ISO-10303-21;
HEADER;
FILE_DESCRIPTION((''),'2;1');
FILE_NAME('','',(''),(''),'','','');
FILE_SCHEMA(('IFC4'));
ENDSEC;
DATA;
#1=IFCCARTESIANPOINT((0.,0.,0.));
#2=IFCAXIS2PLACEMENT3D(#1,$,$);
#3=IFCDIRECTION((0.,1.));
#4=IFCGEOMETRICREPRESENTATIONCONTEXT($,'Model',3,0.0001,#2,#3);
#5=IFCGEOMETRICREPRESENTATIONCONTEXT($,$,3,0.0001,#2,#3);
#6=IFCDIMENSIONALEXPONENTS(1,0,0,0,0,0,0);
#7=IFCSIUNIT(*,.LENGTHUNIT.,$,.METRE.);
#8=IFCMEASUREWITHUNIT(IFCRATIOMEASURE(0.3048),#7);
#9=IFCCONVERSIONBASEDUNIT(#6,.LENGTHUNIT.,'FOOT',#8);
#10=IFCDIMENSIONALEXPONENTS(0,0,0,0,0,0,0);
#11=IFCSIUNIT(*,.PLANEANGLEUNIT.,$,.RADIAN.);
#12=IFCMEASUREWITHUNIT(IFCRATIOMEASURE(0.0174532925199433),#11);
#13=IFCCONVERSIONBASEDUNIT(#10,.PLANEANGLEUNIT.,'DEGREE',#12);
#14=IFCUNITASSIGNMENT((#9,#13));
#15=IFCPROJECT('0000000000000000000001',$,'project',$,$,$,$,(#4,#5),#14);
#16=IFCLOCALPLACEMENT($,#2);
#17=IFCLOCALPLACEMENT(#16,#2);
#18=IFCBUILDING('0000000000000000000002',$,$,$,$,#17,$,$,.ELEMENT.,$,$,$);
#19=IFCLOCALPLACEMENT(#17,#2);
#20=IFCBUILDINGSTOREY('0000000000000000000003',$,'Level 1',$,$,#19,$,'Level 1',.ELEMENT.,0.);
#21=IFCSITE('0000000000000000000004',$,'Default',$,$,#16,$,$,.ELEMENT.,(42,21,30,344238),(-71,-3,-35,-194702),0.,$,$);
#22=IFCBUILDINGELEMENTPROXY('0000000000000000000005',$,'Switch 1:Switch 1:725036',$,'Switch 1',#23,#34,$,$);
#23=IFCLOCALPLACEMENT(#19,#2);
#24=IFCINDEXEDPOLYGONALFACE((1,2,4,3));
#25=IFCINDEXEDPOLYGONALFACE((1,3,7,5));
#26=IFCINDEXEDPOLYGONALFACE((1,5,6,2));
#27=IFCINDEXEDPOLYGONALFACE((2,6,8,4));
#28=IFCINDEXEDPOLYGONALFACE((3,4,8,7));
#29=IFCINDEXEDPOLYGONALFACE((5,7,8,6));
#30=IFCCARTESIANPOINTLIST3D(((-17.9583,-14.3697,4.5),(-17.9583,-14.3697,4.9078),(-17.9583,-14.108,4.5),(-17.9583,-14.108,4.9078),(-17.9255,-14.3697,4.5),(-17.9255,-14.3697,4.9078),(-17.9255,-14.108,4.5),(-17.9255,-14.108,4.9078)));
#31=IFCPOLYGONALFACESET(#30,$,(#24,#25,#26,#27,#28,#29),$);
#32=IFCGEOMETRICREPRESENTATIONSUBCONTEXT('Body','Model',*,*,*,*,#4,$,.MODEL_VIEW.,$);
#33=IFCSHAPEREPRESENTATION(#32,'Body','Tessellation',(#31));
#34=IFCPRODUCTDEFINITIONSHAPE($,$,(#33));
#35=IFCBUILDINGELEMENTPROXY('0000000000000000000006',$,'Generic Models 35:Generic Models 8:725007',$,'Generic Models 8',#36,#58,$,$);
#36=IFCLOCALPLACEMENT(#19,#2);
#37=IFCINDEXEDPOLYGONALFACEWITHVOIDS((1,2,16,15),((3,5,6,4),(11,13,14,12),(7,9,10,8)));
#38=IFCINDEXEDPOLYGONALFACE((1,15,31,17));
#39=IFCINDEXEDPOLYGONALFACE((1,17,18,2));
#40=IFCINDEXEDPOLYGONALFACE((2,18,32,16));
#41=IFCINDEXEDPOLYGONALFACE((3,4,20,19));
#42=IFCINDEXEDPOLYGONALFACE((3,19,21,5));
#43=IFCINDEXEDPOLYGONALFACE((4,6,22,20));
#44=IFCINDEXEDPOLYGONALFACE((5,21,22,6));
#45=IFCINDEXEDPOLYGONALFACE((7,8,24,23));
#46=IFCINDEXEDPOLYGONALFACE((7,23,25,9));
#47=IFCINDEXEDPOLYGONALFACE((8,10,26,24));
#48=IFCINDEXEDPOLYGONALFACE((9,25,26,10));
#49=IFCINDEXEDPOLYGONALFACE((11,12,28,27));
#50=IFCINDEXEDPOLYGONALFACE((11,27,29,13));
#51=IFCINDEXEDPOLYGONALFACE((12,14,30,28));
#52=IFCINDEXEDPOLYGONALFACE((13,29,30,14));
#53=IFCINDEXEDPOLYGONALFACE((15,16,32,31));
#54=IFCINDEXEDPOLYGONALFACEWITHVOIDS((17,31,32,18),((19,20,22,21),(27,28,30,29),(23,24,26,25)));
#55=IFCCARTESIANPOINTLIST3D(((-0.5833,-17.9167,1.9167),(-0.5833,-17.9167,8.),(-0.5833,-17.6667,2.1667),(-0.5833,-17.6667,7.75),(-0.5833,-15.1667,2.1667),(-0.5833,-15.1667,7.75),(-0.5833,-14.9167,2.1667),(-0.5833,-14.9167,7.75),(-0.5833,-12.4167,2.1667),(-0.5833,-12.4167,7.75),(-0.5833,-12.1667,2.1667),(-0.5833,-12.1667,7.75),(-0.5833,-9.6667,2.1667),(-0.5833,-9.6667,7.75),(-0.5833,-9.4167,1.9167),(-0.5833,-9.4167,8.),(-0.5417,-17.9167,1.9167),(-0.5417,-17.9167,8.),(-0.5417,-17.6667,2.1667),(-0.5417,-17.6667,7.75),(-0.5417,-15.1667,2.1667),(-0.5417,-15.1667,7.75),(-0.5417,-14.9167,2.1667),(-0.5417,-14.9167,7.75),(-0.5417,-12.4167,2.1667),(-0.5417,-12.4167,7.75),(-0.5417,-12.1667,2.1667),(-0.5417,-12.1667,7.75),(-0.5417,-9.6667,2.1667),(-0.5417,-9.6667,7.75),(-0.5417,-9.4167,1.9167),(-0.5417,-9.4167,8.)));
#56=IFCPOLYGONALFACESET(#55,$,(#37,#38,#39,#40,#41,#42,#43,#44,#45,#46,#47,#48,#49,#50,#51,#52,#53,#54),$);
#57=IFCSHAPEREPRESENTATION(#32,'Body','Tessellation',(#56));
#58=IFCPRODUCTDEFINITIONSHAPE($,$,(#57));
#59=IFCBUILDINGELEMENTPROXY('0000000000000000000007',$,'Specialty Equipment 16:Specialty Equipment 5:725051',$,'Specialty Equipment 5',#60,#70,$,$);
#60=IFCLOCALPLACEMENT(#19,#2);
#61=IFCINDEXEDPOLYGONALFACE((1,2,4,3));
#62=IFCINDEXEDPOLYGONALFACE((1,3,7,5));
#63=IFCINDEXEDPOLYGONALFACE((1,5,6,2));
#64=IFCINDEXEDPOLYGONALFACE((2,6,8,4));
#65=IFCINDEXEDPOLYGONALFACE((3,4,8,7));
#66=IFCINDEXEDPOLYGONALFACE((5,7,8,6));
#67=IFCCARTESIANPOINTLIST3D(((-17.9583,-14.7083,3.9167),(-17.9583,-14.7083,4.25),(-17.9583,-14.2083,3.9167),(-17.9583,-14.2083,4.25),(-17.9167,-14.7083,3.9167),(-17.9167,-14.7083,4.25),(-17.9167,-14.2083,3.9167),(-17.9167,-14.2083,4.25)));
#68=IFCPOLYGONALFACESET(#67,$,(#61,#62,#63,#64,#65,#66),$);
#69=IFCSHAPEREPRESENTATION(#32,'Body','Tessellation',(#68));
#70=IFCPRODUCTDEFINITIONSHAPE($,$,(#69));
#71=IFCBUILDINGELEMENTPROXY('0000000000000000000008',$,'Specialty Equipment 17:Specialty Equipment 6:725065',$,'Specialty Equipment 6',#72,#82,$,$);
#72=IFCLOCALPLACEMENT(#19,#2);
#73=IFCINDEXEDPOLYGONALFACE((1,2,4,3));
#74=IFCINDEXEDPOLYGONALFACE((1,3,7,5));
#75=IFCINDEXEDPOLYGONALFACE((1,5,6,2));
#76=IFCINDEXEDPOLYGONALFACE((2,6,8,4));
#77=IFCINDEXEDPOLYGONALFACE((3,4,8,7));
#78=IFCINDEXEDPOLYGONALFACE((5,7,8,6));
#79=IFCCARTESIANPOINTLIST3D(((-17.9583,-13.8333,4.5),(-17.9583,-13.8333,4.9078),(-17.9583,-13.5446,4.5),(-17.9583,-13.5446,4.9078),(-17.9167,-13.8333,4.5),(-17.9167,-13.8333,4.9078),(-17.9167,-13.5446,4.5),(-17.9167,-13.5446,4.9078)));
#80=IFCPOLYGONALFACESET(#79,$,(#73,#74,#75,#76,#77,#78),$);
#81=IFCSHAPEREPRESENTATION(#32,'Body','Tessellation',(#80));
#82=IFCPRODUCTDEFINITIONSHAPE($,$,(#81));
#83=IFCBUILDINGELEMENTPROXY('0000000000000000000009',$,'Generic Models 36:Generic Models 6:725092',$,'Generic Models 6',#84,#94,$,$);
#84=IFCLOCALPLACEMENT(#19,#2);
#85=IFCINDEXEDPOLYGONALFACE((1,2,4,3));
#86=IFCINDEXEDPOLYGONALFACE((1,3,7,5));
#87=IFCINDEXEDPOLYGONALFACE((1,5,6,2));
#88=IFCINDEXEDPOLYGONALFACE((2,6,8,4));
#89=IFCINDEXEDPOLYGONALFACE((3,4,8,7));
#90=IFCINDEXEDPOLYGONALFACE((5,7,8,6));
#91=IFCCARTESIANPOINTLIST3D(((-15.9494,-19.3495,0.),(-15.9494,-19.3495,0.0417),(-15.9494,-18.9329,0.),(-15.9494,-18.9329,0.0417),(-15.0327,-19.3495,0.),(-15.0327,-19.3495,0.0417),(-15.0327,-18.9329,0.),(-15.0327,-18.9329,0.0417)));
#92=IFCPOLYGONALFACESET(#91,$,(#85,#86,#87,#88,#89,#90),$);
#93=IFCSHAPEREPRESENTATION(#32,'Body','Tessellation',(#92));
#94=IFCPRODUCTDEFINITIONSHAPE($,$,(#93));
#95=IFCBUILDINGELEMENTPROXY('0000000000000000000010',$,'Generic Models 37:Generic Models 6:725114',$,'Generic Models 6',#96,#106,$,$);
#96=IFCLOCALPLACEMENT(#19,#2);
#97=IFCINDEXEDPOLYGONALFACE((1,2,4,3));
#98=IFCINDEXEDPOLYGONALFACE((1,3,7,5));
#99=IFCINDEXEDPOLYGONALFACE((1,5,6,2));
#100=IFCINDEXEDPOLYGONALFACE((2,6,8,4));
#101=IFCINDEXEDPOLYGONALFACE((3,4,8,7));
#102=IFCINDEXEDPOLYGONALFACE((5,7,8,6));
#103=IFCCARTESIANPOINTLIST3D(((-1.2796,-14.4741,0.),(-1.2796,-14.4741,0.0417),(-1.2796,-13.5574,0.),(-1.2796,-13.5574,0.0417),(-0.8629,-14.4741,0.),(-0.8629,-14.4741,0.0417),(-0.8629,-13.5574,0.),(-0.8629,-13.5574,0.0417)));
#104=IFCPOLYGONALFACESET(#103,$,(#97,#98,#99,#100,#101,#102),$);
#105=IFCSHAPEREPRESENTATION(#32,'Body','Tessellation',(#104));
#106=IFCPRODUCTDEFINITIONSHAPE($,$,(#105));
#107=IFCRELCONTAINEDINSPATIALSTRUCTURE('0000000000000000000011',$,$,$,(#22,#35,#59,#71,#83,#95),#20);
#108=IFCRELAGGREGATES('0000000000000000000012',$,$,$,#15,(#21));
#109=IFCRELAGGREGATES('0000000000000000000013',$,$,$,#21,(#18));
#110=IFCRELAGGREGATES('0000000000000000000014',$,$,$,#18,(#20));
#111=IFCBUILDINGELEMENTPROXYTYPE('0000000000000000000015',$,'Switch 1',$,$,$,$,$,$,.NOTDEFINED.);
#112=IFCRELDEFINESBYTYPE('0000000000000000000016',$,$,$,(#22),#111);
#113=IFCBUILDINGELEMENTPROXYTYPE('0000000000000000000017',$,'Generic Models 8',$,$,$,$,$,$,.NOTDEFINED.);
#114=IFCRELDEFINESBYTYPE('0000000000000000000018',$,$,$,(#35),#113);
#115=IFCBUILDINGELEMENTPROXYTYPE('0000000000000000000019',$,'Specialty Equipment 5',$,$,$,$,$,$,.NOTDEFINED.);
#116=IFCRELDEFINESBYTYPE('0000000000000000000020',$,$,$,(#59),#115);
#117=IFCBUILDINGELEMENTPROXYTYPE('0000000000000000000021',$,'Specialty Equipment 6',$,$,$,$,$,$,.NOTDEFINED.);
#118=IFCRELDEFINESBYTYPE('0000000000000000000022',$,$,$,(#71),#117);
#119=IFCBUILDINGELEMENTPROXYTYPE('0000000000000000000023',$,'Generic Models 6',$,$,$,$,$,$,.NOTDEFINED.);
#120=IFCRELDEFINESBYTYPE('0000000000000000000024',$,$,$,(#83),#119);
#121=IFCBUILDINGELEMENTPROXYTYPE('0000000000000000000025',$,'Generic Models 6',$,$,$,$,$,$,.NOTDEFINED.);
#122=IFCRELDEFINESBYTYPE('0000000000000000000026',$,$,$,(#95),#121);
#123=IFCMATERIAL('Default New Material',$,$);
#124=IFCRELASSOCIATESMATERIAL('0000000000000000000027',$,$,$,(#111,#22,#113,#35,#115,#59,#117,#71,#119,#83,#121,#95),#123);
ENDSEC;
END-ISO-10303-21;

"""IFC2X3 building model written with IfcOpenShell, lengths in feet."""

from ifc_helpers import new_model, entity, si_unit, converted_unit, direction, frame, frame_2d, origin, origin_2d_with_axis, place, context, subcontext, project, spatial, polyline, rectangle, outline, extrude, source, transform, mapped, material, type_object, type_shapes, element, save


model = new_model("IFC2X3")

# Units and contexts
model_context = context("Model", 3, precision=0.0001, world=origin(), true_north=direction((0.0, 1.0)))
context_of_model = context(None, 3, precision=0.0001, world=origin(), true_north=direction((0.0, 1.0)))
body_context = subcontext(model_context, "Body", "Model", "MODEL_VIEW")
ifc_project = project(units=[converted_unit("LENGTHUNIT", "FOOT", entity("IfcRatioMeasure", 0.3048), si_unit("LENGTHUNIT", "METRE"), dimensions=[1, 0, 0, 0, 0, 0, 0]), converted_unit("PLANEANGLEUNIT", "DEGREE", entity("IfcRatioMeasure", 0.0174532925199433), si_unit("PLANEANGLEUNIT", "RADIAN"), dimensions=[0, 0, 0, 0, 0, 0, 0])], contexts=[model_context, context_of_model])

# Site, building, storey
site_placement = place(None, origin())
site = spatial("IfcSite", under=ifc_project, at=site_placement, Name="Default", CompositionType="ELEMENT", RefLatitude=(42, 21, 30, 344238), RefLongitude=(-71, -3, -35, -194702), RefElevation=0.0)
building_placement = place(site_placement, origin())
building = spatial("IfcBuilding", under=site, at=building_placement, CompositionType="ELEMENT")
storey_placement = place(building_placement, origin())
storey = spatial("IfcBuildingStorey", under=building, at=storey_placement, Name="Level 1", LongName="Level 1", CompositionType="ELEMENT", Elevation=0.0)

# Shared definitions
ifc_material = material(Name="Default New Material")

# Building element proxies
building_element_proxy_type_1 = type_object("IfcBuildingElementProxyType", Name="Switch 1", PredefinedType="NOTDEFINED", material=ifc_material)
shared_shape_1 = source(origin(), body_context, "Body", "SweptSolid", [
    extrude(rectangle(XDim=0.0328, YDim=0.2617, at=origin_2d_with_axis()), frame((0.0, -0.0164, 0.0), z_axis=(0.0, 0.0, 1.0), x_axis=(0.0, 1.0, 0.0)), (0.0, 0.0, 1.0), 0.4078),
])
type_shapes(building_element_proxy_type_1, [shared_shape_1])
proxy_1_placement = place(storey_placement, frame((-17.9583, -14.2388, 4.5), z_axis=(0.0, 0.0, 1.0), x_axis=(0.0, 1.0, 0.0)))
element("IfcBuildingElementProxy", 1, at=proxy_1_placement, inside=storey, type_object=building_element_proxy_type_1, material=ifc_material, Name="Switch 1:Switch 1:725036", ObjectType="Switch 1", context=body_context, shape_type="MappedRepresentation", body=[
    mapped(shared_shape_1, transform((0.0, 0.0, 0.0), scale=1.0)),
])
building_element_proxy_type_2 = type_object("IfcBuildingElementProxyType", Name="Generic Models 8", PredefinedType="NOTDEFINED", material=ifc_material)
shared_shape_2 = source(origin(), body_context, "Body", "SweptSolid", [
    extrude(outline(polyline([(-4.25, -3.0417), (4.25, -3.0417), (4.25, 3.0417), (-4.25, 3.0417), (-4.25, -3.0417)]), holes=[polyline([(1.5, 2.7917), (4.0, 2.7917), (4.0, -2.7917), (1.5, -2.7917), (1.5, 2.7917)]), polyline([(-4.0, -2.7917), (-4.0, 2.7917), (-1.5, 2.7917), (-1.5, -2.7917), (-4.0, -2.7917)]), polyline([(1.25, 2.7917), (1.25, -2.7917), (-1.25, -2.7917), (-1.25, 2.7917), (1.25, 2.7917)])]), frame((0.0, 4.25, 3.0417), z_axis=(1.0, 0.0, 0.0), x_axis=(0.0, -1.0, 0.0)), (0.0, 0.0, 1.0), 0.0417),
])
type_shapes(building_element_proxy_type_2, [shared_shape_2])
proxy_2_placement = place(storey_placement, frame((-0.5833, -17.9167, 1.9167)))
element("IfcBuildingElementProxy", 2, at=proxy_2_placement, inside=storey, type_object=building_element_proxy_type_2, material=ifc_material, Name="Generic Models 35:Generic Models 8:725007", ObjectType="Generic Models 8", context=body_context, shape_type="MappedRepresentation", body=[
    mapped(shared_shape_2, transform((0.0, 0.0, 0.0), scale=1.0)),
])
building_element_proxy_type_3 = type_object("IfcBuildingElementProxyType", Name="Specialty Equipment 5", PredefinedType="NOTDEFINED", material=ifc_material)
shared_shape_3 = source(origin(), body_context, "Body", "SweptSolid", [
    extrude(rectangle(XDim=0.0417, YDim=0.5, at=frame_2d((0.0, 0.0), x_axis=(1.0, 0.0))), frame((0.0208, 0.25, 0.0), z_axis=(0.0, 0.0, 1.0), x_axis=(-1.0, 0.0, 0.0)), (0.0, 0.0, 1.0), 0.3333),
])
type_shapes(building_element_proxy_type_3, [shared_shape_3])
proxy_3_placement = place(storey_placement, frame((-17.9583, -14.7083, 3.9167)))
element("IfcBuildingElementProxy", 3, at=proxy_3_placement, inside=storey, type_object=building_element_proxy_type_3, material=ifc_material, Name="Specialty Equipment 16:Specialty Equipment 5:725051", ObjectType="Specialty Equipment 5", context=body_context, shape_type="MappedRepresentation", body=[
    mapped(shared_shape_3, transform((0.0, 0.0, 0.0), scale=1.0)),
])
building_element_proxy_type_4 = type_object("IfcBuildingElementProxyType", Name="Specialty Equipment 6", PredefinedType="NOTDEFINED", material=ifc_material)
shared_shape_4 = source(origin(), body_context, "Body", "SweptSolid", [
    extrude(rectangle(XDim=0.0417, YDim=0.2888, at=frame_2d((0.0, 0.0), x_axis=(1.0, 0.0))), frame((0.0208, 0.1444, 0.0), z_axis=(0.0, 0.0, 1.0), x_axis=(-1.0, 0.0, 0.0)), (0.0, 0.0, 1.0), 0.4078),
])
type_shapes(building_element_proxy_type_4, [shared_shape_4])
proxy_4_placement = place(storey_placement, frame((-17.9583, -13.8333, 4.5)))
element("IfcBuildingElementProxy", 4, at=proxy_4_placement, inside=storey, type_object=building_element_proxy_type_4, material=ifc_material, Name="Specialty Equipment 17:Specialty Equipment 6:725065", ObjectType="Specialty Equipment 6", context=body_context, shape_type="MappedRepresentation", body=[
    mapped(shared_shape_4, transform((0.0, 0.0, 0.0), scale=1.0)),
])
building_element_proxy_type_5 = type_object("IfcBuildingElementProxyType", Name="Generic Models 6", PredefinedType="NOTDEFINED", material=ifc_material)
shared_shape_5 = source(origin(), body_context, "Body", "SweptSolid", [
    extrude(rectangle(XDim=0.9167, YDim=0.4167, at=frame_2d((0.0, 0.0), x_axis=(1.0, 0.0))), frame((0.4583, 0.2083, 0.0), z_axis=(0.0, 0.0, 1.0), x_axis=(-1.0, 0.0, 0.0)), (0.0, 0.0, 1.0), 0.0417),
])
type_shapes(building_element_proxy_type_5, [shared_shape_5])
proxy_5_placement = place(storey_placement, frame((-15.9494, -19.3495, 0.0)))
element("IfcBuildingElementProxy", 5, at=proxy_5_placement, inside=storey, type_object=building_element_proxy_type_5, material=ifc_material, Name="Generic Models 36:Generic Models 6:725092", ObjectType="Generic Models 6", context=body_context, shape_type="MappedRepresentation", body=[
    mapped(shared_shape_5, transform((0.0, 0.0, 0.0), scale=1.0)),
])
building_element_proxy_type_6 = type_object("IfcBuildingElementProxyType", Name="Generic Models 6", PredefinedType="NOTDEFINED", material=ifc_material)
shared_shape_6 = source(origin(), body_context, "Body", "SweptSolid", [
    extrude(rectangle(XDim=0.9167, YDim=0.4167, at=frame_2d((0.0, 0.0), x_axis=(1.0, 0.0))), frame((0.4583, 0.2083, 0.0), z_axis=(0.0, 0.0, 1.0), x_axis=(-1.0, 0.0, 0.0)), (0.0, 0.0, 1.0), 0.0417),
])
type_shapes(building_element_proxy_type_6, [shared_shape_6])
proxy_6_placement = place(storey_placement, frame((-0.8629, -14.4741, 0.0), z_axis=(0.0, 0.0, 1.0), x_axis=(0.0, 1.0, 0.0)))
element("IfcBuildingElementProxy", 6, at=proxy_6_placement, inside=storey, type_object=building_element_proxy_type_6, material=ifc_material, Name="Generic Models 37:Generic Models 6:725114", ObjectType="Generic Models 6", context=body_context, shape_type="MappedRepresentation", body=[
    mapped(shared_shape_6, transform((0.0, 0.0, 0.0), scale=1.0)),
])

save(model, "model.ifc")
